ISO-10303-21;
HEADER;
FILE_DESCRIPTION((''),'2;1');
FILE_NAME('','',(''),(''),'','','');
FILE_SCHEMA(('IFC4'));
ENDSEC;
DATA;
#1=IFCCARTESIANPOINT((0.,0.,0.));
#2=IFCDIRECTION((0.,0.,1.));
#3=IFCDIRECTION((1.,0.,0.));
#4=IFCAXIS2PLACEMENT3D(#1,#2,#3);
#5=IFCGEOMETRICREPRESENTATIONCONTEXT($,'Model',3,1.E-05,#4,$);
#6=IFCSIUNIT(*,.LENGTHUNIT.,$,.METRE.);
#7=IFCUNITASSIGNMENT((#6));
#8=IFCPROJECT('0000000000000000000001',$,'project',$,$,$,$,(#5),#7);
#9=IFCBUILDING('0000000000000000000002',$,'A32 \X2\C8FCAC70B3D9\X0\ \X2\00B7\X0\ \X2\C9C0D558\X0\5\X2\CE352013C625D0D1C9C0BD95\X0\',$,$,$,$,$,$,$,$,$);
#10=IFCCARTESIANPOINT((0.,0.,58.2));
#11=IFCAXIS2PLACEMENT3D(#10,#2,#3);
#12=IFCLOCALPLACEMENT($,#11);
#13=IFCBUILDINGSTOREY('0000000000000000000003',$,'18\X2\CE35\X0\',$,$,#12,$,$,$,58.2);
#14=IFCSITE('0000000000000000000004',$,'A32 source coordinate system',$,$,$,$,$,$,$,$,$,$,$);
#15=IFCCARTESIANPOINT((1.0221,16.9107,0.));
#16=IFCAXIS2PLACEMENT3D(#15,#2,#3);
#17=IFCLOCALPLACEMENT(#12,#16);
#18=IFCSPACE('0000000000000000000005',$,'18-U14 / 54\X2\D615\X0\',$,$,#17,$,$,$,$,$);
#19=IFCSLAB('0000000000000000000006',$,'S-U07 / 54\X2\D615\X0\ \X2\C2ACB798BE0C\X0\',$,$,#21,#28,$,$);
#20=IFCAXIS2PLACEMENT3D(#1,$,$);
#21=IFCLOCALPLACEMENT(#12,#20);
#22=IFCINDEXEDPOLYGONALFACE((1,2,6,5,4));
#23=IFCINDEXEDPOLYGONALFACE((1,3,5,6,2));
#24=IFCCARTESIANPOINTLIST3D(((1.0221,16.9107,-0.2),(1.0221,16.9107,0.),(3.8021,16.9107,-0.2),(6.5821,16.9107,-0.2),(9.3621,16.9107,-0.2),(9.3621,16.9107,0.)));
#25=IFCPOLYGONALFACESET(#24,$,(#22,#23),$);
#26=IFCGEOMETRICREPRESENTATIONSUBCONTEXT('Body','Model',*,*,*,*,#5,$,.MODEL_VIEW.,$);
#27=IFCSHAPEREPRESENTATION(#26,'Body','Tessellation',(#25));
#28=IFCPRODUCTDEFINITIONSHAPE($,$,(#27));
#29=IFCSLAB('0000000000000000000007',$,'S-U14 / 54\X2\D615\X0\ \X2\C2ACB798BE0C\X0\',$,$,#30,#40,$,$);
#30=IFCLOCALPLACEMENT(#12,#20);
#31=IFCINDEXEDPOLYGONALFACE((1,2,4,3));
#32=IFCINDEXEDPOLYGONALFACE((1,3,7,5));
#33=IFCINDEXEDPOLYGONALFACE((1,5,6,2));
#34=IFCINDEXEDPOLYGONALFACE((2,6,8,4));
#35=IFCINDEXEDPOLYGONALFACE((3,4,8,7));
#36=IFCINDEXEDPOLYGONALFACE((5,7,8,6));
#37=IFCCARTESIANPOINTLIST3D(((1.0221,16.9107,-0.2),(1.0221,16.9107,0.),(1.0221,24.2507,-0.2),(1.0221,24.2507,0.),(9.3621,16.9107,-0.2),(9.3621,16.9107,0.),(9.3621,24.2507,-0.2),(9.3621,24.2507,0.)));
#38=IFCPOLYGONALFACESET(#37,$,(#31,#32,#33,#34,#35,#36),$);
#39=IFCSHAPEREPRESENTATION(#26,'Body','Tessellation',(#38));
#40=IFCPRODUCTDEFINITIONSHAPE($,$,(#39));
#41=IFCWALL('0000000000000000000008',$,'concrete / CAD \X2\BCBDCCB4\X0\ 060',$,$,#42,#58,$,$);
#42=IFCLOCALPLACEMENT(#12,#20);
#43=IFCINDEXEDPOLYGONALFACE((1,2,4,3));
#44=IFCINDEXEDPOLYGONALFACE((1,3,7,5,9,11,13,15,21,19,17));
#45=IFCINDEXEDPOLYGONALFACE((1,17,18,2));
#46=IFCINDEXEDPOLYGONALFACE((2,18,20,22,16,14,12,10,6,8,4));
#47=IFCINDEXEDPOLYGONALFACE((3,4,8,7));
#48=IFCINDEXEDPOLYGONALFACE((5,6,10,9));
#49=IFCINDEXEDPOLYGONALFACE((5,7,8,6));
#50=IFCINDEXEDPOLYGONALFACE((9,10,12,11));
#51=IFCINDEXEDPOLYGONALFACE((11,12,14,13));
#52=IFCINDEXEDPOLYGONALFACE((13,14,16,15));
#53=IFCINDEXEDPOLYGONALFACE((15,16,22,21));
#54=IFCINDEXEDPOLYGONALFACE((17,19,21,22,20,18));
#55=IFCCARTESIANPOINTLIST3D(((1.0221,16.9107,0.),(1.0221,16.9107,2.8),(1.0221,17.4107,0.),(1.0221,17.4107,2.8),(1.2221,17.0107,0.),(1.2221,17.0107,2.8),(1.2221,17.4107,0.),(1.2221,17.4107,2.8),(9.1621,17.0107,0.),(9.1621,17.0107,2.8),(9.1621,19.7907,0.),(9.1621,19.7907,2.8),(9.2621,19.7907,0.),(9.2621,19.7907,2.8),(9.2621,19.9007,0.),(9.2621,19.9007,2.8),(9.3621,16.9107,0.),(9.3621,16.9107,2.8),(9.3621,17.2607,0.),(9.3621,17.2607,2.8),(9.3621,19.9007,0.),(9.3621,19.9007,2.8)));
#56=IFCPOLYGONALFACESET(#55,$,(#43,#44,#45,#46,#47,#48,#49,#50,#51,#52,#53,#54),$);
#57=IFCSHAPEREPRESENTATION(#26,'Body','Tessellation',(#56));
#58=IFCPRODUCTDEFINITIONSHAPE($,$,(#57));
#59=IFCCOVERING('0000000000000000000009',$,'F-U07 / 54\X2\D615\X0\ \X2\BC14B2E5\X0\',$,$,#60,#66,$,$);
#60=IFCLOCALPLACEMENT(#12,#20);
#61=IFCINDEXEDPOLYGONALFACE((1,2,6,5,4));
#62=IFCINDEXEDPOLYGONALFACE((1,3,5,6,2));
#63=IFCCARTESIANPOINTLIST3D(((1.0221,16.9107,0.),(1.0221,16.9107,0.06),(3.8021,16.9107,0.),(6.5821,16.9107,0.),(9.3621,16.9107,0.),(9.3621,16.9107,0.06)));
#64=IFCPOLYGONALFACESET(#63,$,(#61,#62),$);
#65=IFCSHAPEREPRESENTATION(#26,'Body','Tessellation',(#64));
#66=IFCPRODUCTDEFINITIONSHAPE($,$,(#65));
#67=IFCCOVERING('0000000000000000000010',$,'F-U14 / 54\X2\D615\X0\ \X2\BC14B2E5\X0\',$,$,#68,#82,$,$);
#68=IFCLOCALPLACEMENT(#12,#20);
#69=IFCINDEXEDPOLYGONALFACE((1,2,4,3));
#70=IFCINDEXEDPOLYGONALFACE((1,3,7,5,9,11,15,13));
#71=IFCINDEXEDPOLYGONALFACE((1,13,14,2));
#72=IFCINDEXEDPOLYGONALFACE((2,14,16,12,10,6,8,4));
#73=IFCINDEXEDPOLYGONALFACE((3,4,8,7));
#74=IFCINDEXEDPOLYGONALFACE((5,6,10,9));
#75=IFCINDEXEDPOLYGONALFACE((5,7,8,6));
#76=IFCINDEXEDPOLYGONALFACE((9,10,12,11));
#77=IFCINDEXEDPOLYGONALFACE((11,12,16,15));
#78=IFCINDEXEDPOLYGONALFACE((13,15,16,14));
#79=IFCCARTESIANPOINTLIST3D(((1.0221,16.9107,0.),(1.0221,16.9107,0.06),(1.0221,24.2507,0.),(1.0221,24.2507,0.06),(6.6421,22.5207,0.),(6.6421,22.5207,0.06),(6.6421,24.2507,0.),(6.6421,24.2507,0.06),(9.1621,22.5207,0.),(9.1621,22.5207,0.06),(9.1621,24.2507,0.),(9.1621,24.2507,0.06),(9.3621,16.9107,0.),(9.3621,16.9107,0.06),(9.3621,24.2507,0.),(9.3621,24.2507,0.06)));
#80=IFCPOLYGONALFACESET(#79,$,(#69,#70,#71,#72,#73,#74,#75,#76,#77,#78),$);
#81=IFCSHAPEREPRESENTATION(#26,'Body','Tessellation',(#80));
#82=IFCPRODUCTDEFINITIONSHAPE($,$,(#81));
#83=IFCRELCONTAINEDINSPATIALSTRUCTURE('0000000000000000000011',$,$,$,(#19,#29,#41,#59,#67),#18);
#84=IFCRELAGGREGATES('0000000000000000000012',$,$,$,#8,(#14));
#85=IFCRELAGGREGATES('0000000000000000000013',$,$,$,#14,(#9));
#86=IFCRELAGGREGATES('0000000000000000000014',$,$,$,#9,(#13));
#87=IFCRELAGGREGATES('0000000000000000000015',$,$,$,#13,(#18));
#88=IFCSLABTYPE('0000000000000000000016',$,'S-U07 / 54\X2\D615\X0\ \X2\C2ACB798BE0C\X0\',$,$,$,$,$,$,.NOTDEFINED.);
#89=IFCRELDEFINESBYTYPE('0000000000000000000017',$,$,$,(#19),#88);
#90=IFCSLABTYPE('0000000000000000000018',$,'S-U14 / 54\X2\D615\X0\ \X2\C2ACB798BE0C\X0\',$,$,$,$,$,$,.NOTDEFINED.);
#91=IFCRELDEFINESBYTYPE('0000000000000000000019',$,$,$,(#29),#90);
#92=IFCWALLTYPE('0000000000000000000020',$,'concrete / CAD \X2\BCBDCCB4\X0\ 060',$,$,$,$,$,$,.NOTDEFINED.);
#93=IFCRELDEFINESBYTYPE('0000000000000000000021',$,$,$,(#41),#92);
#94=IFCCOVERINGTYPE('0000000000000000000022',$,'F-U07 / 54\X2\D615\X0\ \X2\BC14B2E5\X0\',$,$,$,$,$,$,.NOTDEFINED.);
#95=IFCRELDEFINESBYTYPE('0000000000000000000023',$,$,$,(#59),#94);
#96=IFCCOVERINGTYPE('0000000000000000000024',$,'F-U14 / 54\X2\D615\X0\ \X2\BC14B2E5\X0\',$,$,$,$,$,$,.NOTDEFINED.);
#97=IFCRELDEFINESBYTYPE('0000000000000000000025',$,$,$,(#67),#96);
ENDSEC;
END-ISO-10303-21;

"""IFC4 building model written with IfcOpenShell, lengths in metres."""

from ifc_helpers import new_model, si_unit, frame, origin, origin_with_axes, place, context, subcontext, project, spatial, polyline, outline, extrude, source, transform, mapped, type_object, type_shapes, element, save


model = new_model("IFC4")

# Units and contexts
model_context = context("Model", 3, precision=1e-05, world=origin_with_axes())
body_context = subcontext(model_context, "Body", "Model", "MODEL_VIEW")
ifc_project = project(units=[si_unit("LENGTHUNIT", "METRE")], contexts=[model_context])

# Site, building, storey, space
storey_placement = place(None, frame((0.0, 0.0, 58.2), z_axis=(0.0, 0.0, 1.0), x_axis=(1.0, 0.0, 0.0)))
space_1_placement = place(storey_placement, frame((1.0221, 16.9107, 0.0), z_axis=(0.0, 0.0, 1.0), x_axis=(1.0, 0.0, 0.0)))
site = spatial("IfcSite", under=ifc_project, Name="A32 source coordinate system")
building = spatial("IfcBuilding", under=site, Name="A32 주거동 · 지하5층–옥탑지붕")
storey = spatial("IfcBuildingStorey", under=building, at=storey_placement, Name="18층", Elevation=58.2)
space_1 = spatial("IfcSpace", under=storey, at=space_1_placement, Name="18-U14 / 54형")

# Slabs
slab_type_1 = type_object("IfcSlabType", Name="S-U07 / 54형 슬래브", PredefinedType="NOTDEFINED")
shared_shape_1 = source(origin(), body_context, "Body", "SweptSolid", [
    extrude(outline(polyline([(0.0, 0.0), (0.0, 0.0), (8.34, 0.0), (8.34, 0.0), (0.0, 0.0)])), frame((0.0, 0.0, -0.2)), (0.0, 0.0, 1.0), 0.2),
])
type_shapes(slab_type_1, [shared_shape_1])
slab_1_placement = place(space_1_placement, origin_with_axes())
element("IfcSlab", 1, at=slab_1_placement, inside=space_1, type_object=slab_type_1, Name="S-U07 / 54형 슬래브", context=body_context, shape_type="MappedRepresentation", body=[
    mapped(shared_shape_1, transform((0.0, 0.0, 0.0), scale=1.0)),
])
slab_type_2 = type_object("IfcSlabType", Name="S-U14 / 54형 슬래브", PredefinedType="NOTDEFINED")
shared_shape_2 = source(origin(), body_context, "Body", "SweptSolid", [
    extrude(outline(polyline([(0.0, 0.0), (0.0, 7.34), (8.34, 7.34), (8.34, 0.0), (0.0, 0.0)])), frame((0.0, 0.0, -0.2)), (0.0, 0.0, 1.0), 0.2),
])
type_shapes(slab_type_2, [shared_shape_2])
slab_2_placement = place(space_1_placement, origin_with_axes())
element("IfcSlab", 2, at=slab_2_placement, inside=space_1, type_object=slab_type_2, Name="S-U14 / 54형 슬래브", context=body_context, shape_type="MappedRepresentation", body=[
    mapped(shared_shape_2, transform((0.0, 0.0, 0.0), scale=1.0)),
])

# Wall
wall_type_1 = type_object("IfcWallType", Name="concrete / CAD 벽체 060", PredefinedType="NOTDEFINED")
shared_shape_3 = source(origin(), body_context, "Body", "SweptSolid", [
    extrude(outline(polyline([(0.2, 0.5), (0.2, 0.1), (8.14, 0.1), (8.14, 2.88), (8.24, 2.88), (8.24, 2.99), (8.34, 2.99), (8.34, 0.35), (8.34, 0.35), (8.34, 0.0), (0.0, 0.0), (0.0, 0.5), (0.2, 0.5)])), origin(), (0.0, 0.0, 1.0), 2.8),
])
type_shapes(wall_type_1, [shared_shape_3])
wall_1_placement = place(space_1_placement, origin_with_axes())
element("IfcWall", 3, at=wall_1_placement, inside=space_1, type_object=wall_type_1, Name="concrete / CAD 벽체 060", context=body_context, shape_type="MappedRepresentation", body=[
    mapped(shared_shape_3, transform((0.0, 0.0, 0.0), scale=1.0)),
])

# Coverings
covering_type_1 = type_object("IfcCoveringType", Name="F-U07 / 54형 바닥", PredefinedType="NOTDEFINED")
shared_shape_4 = source(origin(), body_context, "Body", "SweptSolid", [
    extrude(outline(polyline([(0.0, 0.0), (0.0, 0.0), (8.34, 0.0), (8.34, 0.0), (0.0, 0.0)])), origin(), (0.0, 0.0, 1.0), 0.06),
])
type_shapes(covering_type_1, [shared_shape_4])
covering_1_placement = place(space_1_placement, origin_with_axes())
element("IfcCovering", 4, at=covering_1_placement, inside=space_1, type_object=covering_type_1, Name="F-U07 / 54형 바닥", context=body_context, shape_type="MappedRepresentation", body=[
    mapped(shared_shape_4, transform((0.0, 0.0, 0.0), scale=1.0)),
])
covering_type_2 = type_object("IfcCoveringType", Name="F-U14 / 54형 바닥", PredefinedType="NOTDEFINED")
shared_shape_5 = source(origin(), body_context, "Body", "SweptSolid", [
    extrude(outline(polyline([(8.14, 7.34), (8.34, 7.34), (8.34, 0.0), (0.0, 0.0), (0.0, 7.34), (5.62, 7.34), (5.62, 5.61), (8.14, 5.61), (8.14, 7.34)])), origin(), (0.0, 0.0, 1.0), 0.06),
])
type_shapes(covering_type_2, [shared_shape_5])
covering_2_placement = place(space_1_placement, origin_with_axes())
element("IfcCovering", 5, at=covering_2_placement, inside=space_1, type_object=covering_type_2, Name="F-U14 / 54형 바닥", context=body_context, shape_type="MappedRepresentation", body=[
    mapped(shared_shape_5, transform((0.0, 0.0, 0.0), scale=1.0)),
])

save(model, "model.ifc")
